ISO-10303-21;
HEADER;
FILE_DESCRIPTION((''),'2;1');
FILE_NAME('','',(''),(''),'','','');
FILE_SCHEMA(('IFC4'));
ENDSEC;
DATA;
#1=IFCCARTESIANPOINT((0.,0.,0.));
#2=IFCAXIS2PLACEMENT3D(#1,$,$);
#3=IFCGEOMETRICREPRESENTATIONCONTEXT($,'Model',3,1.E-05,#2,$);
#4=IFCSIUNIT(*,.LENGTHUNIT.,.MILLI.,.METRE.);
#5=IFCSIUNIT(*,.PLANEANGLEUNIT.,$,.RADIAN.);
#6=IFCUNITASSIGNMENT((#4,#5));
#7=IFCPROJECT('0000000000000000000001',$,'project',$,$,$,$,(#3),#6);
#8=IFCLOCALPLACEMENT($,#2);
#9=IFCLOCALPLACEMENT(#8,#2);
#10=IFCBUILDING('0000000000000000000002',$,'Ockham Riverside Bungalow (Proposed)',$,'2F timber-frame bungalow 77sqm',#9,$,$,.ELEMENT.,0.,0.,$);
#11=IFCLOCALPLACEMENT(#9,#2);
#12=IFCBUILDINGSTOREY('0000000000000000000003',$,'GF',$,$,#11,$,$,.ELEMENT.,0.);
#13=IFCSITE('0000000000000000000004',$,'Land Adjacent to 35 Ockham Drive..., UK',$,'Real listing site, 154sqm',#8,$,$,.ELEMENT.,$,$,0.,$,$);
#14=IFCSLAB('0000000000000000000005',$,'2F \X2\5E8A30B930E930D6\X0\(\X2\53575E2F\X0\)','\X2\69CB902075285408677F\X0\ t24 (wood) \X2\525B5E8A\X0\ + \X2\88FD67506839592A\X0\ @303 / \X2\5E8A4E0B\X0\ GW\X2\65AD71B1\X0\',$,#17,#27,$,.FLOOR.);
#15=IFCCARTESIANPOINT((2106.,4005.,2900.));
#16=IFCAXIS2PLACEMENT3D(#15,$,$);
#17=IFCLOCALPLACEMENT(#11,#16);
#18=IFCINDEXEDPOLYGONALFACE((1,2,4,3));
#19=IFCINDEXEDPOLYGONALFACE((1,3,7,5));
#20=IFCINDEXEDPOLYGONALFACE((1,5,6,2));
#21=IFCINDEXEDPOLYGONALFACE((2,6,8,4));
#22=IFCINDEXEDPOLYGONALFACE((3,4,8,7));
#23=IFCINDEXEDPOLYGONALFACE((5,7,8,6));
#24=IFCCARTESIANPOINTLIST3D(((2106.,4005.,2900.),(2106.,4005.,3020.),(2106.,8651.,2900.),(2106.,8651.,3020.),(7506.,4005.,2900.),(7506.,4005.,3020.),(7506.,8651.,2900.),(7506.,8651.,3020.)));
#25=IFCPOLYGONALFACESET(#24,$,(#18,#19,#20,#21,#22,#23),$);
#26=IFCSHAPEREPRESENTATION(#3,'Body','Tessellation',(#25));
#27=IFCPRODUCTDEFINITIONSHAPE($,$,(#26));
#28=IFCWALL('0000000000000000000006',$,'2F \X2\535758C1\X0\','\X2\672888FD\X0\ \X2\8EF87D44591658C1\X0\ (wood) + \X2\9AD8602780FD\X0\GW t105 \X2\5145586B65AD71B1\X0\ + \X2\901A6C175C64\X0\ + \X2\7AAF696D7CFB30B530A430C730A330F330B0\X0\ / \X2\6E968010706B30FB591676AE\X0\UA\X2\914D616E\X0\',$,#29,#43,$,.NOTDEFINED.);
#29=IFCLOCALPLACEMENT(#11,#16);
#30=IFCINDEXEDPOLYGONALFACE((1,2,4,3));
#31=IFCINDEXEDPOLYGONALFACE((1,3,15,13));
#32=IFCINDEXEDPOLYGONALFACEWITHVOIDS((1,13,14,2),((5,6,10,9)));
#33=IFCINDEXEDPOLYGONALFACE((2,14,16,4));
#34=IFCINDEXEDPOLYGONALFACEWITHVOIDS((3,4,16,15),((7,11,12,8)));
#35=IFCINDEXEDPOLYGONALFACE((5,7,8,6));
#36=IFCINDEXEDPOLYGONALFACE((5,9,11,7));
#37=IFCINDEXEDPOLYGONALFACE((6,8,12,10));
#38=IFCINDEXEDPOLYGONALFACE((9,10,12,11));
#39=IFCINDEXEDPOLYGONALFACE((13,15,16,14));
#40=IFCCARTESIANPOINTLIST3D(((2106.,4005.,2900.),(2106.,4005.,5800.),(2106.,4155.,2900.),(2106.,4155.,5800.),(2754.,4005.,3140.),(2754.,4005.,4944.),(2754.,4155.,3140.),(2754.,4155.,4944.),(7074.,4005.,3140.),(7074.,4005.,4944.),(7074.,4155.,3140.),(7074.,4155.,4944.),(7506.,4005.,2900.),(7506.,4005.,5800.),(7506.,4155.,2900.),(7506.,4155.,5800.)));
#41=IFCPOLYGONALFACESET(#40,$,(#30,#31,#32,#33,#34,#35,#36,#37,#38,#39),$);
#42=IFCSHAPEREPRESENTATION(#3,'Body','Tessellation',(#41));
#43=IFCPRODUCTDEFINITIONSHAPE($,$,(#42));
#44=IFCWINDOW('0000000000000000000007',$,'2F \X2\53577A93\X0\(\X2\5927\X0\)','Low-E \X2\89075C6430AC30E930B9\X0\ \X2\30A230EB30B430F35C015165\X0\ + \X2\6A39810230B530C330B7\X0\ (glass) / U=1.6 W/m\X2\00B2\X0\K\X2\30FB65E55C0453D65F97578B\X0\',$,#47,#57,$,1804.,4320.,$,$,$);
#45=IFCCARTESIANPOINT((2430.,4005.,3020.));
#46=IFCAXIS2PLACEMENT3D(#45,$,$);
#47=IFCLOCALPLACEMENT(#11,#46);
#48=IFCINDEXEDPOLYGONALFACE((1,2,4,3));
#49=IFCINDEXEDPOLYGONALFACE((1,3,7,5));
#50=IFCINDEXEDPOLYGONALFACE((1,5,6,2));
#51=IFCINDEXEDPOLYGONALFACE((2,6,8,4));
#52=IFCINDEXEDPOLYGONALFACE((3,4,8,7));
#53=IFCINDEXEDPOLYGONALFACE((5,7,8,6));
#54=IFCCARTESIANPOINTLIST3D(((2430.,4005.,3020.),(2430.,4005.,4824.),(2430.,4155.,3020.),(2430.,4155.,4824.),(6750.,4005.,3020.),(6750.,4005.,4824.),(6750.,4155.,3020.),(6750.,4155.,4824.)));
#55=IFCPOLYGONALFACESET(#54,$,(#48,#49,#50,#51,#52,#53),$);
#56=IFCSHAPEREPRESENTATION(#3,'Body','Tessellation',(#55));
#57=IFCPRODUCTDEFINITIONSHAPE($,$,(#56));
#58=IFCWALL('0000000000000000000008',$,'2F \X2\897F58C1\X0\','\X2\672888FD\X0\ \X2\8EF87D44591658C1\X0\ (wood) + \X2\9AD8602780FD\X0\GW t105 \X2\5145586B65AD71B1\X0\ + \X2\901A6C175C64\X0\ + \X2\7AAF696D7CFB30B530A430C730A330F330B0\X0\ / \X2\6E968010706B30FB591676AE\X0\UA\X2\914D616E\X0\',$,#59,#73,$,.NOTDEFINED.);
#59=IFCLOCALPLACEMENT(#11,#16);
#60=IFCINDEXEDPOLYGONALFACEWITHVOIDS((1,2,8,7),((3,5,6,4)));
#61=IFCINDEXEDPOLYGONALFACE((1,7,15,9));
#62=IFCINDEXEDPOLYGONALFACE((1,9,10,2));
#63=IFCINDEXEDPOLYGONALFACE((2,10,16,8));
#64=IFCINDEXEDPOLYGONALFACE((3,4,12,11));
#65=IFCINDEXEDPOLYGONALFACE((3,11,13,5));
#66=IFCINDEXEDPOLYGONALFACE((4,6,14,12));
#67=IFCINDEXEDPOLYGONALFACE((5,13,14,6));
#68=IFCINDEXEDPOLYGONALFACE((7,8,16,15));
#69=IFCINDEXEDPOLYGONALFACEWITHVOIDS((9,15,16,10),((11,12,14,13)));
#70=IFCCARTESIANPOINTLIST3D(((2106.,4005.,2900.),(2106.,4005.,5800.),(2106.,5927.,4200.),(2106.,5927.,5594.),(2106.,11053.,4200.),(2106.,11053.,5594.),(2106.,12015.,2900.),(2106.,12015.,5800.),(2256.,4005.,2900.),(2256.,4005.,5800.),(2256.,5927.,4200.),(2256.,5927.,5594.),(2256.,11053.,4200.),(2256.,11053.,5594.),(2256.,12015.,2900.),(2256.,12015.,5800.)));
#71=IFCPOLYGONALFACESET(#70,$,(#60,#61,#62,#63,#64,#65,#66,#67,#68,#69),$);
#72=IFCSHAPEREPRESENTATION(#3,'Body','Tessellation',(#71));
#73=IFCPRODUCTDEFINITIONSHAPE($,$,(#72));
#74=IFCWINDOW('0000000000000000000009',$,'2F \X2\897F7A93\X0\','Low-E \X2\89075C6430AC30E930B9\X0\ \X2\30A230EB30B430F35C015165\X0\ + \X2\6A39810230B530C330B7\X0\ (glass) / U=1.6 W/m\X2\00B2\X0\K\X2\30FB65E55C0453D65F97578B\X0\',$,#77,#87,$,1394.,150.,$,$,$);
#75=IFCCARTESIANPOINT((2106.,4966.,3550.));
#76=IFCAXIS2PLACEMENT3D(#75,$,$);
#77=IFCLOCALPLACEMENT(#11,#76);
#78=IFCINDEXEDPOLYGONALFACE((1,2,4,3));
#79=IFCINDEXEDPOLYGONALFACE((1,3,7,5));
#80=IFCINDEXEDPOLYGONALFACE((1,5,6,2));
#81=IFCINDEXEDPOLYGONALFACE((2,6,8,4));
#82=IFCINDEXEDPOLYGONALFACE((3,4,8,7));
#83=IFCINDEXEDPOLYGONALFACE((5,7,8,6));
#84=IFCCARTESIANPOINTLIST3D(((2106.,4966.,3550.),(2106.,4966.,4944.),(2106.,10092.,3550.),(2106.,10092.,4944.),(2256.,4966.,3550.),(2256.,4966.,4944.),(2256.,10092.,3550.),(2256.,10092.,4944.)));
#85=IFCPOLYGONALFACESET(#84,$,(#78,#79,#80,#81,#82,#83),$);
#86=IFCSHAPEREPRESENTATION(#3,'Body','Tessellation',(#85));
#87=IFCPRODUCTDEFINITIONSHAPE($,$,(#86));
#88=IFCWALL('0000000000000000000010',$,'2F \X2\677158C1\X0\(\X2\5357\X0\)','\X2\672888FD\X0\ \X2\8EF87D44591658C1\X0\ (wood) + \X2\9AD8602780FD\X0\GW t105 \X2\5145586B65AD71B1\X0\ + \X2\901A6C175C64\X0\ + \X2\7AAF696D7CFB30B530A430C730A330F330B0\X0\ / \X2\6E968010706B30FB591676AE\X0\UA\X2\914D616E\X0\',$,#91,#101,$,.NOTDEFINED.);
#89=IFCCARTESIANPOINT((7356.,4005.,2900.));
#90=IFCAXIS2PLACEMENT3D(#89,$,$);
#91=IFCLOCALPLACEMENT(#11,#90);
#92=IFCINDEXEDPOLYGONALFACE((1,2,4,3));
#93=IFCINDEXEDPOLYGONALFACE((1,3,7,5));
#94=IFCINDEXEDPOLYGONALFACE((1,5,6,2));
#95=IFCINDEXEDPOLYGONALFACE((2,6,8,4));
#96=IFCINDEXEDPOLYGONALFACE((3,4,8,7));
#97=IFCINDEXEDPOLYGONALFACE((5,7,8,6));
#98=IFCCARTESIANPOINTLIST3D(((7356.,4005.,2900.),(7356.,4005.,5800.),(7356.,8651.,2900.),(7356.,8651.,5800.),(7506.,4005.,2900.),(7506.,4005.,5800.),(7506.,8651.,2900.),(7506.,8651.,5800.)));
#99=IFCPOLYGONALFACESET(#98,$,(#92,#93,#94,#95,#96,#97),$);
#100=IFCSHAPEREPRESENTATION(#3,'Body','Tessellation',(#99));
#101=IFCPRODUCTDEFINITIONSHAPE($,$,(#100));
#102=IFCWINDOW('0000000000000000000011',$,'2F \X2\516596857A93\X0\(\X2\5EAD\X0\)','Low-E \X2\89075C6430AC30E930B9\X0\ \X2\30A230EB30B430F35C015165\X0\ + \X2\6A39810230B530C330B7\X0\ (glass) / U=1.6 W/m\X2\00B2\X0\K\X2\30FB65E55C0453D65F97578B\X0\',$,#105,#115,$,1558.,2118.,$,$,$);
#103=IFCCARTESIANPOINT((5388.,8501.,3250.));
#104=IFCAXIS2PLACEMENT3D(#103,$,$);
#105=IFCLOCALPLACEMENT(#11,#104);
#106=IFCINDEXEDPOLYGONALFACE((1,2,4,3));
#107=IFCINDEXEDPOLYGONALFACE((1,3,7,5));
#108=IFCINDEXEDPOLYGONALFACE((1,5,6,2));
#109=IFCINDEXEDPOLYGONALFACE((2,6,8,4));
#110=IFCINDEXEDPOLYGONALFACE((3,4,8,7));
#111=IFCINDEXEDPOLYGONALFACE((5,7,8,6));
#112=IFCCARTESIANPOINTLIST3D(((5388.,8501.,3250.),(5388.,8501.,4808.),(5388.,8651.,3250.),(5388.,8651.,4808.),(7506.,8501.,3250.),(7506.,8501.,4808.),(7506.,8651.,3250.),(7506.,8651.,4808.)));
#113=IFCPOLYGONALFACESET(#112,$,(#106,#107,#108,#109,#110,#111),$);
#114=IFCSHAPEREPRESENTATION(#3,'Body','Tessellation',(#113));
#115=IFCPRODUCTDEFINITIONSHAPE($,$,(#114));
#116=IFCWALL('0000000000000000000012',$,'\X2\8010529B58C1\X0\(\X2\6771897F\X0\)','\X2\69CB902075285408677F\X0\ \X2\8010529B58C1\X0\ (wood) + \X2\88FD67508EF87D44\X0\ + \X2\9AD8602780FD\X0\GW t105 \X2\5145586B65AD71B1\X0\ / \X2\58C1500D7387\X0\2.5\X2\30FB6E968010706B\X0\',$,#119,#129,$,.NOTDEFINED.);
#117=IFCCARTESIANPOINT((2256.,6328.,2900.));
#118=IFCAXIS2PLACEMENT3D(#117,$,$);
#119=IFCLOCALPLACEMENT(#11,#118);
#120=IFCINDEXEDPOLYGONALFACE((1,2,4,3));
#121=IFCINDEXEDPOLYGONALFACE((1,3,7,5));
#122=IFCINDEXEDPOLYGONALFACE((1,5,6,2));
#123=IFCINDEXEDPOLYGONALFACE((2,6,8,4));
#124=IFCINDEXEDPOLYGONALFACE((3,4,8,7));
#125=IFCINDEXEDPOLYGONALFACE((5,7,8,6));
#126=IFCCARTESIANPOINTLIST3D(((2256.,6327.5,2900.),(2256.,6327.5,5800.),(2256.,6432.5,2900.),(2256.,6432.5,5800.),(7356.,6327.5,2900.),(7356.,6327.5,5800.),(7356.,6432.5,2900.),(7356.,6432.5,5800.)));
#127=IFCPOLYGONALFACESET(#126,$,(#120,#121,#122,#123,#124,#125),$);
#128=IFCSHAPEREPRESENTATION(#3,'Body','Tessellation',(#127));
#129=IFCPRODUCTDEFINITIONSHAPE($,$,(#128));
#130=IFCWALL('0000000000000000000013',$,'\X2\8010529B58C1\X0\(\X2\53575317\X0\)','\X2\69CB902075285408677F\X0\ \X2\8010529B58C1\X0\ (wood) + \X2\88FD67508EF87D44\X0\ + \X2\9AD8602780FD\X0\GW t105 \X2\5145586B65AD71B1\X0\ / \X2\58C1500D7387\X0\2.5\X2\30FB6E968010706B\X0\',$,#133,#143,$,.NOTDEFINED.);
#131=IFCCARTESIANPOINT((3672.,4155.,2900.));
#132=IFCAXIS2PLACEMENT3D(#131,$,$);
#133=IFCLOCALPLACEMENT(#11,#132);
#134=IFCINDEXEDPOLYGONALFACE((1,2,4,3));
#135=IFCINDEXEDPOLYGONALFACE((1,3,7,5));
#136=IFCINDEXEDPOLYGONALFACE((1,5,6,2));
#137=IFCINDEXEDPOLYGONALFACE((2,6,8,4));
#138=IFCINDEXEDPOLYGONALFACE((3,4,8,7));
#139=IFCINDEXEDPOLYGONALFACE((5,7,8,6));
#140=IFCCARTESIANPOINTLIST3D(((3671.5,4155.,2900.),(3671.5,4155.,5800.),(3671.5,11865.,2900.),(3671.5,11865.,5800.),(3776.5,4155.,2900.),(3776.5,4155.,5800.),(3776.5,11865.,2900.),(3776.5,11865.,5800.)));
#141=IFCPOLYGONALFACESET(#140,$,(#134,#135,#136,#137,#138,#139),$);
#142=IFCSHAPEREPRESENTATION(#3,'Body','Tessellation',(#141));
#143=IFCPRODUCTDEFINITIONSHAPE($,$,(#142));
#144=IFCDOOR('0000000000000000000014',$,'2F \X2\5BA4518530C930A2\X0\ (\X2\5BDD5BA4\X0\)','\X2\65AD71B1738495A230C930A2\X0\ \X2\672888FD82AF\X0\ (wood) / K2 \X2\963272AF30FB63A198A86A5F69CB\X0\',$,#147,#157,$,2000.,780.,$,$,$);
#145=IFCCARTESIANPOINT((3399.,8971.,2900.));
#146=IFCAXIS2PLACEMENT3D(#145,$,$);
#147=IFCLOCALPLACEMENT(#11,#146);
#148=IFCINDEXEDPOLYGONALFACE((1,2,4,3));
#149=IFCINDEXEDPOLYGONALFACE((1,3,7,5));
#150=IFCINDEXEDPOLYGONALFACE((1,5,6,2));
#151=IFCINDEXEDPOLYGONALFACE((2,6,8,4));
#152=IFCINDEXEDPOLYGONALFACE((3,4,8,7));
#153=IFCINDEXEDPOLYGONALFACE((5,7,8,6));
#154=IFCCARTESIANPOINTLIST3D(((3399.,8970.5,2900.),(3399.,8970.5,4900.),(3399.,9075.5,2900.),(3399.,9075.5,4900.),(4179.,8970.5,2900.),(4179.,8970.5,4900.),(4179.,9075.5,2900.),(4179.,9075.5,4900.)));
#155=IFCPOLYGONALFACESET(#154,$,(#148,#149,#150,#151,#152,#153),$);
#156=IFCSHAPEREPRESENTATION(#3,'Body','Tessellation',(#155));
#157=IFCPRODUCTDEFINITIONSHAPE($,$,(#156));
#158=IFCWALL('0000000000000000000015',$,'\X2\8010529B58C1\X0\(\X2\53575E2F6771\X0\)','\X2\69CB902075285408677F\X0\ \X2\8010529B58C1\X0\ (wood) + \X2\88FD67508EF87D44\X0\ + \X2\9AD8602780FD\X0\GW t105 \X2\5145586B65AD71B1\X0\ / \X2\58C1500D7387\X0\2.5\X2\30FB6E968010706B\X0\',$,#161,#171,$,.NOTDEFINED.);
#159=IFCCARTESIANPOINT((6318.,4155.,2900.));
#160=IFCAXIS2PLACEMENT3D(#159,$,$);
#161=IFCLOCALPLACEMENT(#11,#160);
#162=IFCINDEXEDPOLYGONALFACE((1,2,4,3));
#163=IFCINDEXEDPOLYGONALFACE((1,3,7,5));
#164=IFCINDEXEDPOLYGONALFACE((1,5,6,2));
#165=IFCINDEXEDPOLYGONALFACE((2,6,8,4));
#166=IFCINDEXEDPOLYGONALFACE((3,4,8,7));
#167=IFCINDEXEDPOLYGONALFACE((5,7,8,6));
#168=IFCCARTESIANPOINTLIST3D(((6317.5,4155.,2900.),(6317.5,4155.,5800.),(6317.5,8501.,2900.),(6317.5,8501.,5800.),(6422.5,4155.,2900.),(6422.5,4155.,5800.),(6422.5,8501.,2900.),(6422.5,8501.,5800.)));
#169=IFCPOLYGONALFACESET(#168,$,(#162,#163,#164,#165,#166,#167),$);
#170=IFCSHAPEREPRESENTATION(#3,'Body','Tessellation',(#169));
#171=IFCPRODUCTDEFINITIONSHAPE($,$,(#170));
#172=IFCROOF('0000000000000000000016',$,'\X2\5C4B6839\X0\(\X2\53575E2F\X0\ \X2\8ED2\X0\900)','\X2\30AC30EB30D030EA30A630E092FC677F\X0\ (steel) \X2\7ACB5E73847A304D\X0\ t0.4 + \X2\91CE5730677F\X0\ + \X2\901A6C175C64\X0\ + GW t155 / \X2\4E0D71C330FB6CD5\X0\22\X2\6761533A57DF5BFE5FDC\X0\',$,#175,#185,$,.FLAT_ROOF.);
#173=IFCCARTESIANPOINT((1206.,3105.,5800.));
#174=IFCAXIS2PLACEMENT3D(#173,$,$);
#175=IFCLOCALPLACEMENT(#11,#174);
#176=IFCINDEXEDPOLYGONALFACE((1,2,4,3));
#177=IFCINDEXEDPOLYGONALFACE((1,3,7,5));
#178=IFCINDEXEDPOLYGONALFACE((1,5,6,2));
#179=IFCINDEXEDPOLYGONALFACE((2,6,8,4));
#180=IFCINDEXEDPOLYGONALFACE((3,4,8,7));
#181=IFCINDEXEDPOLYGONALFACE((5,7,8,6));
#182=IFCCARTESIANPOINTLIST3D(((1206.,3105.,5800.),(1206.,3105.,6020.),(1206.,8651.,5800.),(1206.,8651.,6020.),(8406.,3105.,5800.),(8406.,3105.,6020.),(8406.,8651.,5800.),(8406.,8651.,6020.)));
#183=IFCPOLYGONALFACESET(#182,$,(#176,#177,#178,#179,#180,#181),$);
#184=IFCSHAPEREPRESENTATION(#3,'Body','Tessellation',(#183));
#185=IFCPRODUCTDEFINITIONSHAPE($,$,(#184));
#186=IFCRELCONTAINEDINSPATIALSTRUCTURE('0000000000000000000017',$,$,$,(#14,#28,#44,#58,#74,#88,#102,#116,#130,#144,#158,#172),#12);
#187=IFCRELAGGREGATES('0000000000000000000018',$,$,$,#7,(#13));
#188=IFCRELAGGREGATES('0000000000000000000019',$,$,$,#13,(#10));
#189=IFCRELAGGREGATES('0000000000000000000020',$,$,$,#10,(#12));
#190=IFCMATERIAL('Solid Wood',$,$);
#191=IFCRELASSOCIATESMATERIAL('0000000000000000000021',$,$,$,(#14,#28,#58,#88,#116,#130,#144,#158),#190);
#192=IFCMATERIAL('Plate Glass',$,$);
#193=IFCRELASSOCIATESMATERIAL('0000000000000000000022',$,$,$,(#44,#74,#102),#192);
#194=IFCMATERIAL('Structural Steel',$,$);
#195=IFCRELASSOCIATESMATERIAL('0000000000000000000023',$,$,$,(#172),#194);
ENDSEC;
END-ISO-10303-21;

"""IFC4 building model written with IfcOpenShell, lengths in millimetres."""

from ifc_helpers import new_model, si_unit, frame, frame_2d, origin, place, context, project, spatial, rectangle, extrude, material, element, fill, save


model = new_model("IFC4")

# Units and contexts
model_context = context("Model", 3, precision=1e-05, world=origin())
ifc_project = project(units=[si_unit("LENGTHUNIT", "METRE", prefix="MILLI"), si_unit("PLANEANGLEUNIT", "RADIAN")], contexts=[model_context])

# Site, building, storey
site_placement = place(None, origin())
site = spatial("IfcSite", under=ifc_project, at=site_placement, Name="Land Adjacent to 35 Ockham Drive..., UK", ObjectType="Real listing site, 154sqm", CompositionType="ELEMENT", RefElevation=0.0)
building_placement = place(site_placement, origin())
building = spatial("IfcBuilding", under=site, at=building_placement, Name="Ockham Riverside Bungalow (Proposed)", ObjectType="2F timber-frame bungalow 77sqm", CompositionType="ELEMENT", ElevationOfRefHeight=0.0, ElevationOfTerrain=0.0)
storey_placement = place(building_placement, origin())
storey = spatial("IfcBuildingStorey", under=building, at=storey_placement, Name="GF", CompositionType="ELEMENT", Elevation=0.0)

# Slab
ifc_material_1 = material(Name="Solid Wood")
slab_placement = place(storey_placement, frame((2106.0, 4005.0, 2900.0)))
element("IfcSlab", 1, at=slab_placement, inside=storey, material=ifc_material_1, Name="2F 床スラブ(南帯)", Description="構造用合板 t24 (wood) 剛床 + 製材根太 @303 / 床下 GW断熱", PredefinedType="FLOOR", context=model_context, shape_type="SweptSolid", body=[
    extrude(rectangle(XDim=5400.0, YDim=4646.0, at=frame_2d((2700.0, 2323.0))), frame((2106.0, 4005.0, 2900.0)), (0.0, 0.0, 1.0), 120.0),
])

# Walls, openings, windows
wall_1_placement = place(storey_placement, frame((2106.0, 4005.0, 2900.0)))
wall_1 = element("IfcWall", 2, at=wall_1_placement, inside=storey, material=ifc_material_1, Name="2F 南壁", Description="木製 軸組外壁 (wood) + 高性能GW t105 充填断熱 + 通気層 + 窯業系サイディング / 準耐火・外皮UA配慮", PredefinedType="NOTDEFINED", context=model_context, shape_type="SweptSolid", body=[
    extrude(rectangle(XDim=5400.0, YDim=150.0, at=frame_2d((2700.0, 75.0))), frame((2106.0, 4005.0, 2900.0)), (0.0, 0.0, 1.0), 2900.0),
])
opening_1_placement = place(storey_placement, frame((2430.0, 4005.0, 3020.0)))
opening_1 = element("IfcOpeningElement", 3, at=opening_1_placement, cuts=wall_1, PredefinedType="NOTDEFINED", context=model_context, shape_type="SweptSolid", body=[
    extrude(rectangle(XDim=4320.0, YDim=150.0, at=frame_2d((2160.0, 75.0))), frame((2430.0, 4005.0, 3020.0)), (0.0, 0.0, 1.0), 1804.0),
])
ifc_material_2 = material(Name="Plate Glass")
window_1_placement = place(storey_placement, frame((2430.0, 4005.0, 3020.0)))
window_1 = element("IfcWindow", 4, at=window_1_placement, inside=storey, material=ifc_material_2, Name="2F 南窓(大)", Description="Low-E 複層ガラス アルゴン封入 + 樹脂サッシ (glass) / U=1.6 W/m²K・日射取得型", OverallHeight=1804.0, OverallWidth=4320.0, context=model_context, shape_type="SweptSolid", body=[
    extrude(rectangle(XDim=4320.0, YDim=150.0, at=frame_2d((2160.0, 75.0))), frame((2430.0, 4005.0, 3020.0)), (0.0, 0.0, 1.0), 1804.0),
])
fill(opening_1, window_1)
wall_2_placement = place(storey_placement, frame((2106.0, 4005.0, 2900.0)))
wall_2 = element("IfcWall", 5, at=wall_2_placement, inside=storey, material=ifc_material_1, Name="2F 西壁", Description="木製 軸組外壁 (wood) + 高性能GW t105 充填断熱 + 通気層 + 窯業系サイディング / 準耐火・外皮UA配慮", PredefinedType="NOTDEFINED", context=model_context, shape_type="SweptSolid", body=[
    extrude(rectangle(XDim=150.0, YDim=8010.0, at=frame_2d((75.0, 4005.0))), frame((2106.0, 4005.0, 2900.0)), (0.0, 0.0, 1.0), 2900.0),
])
opening_2_placement = place(storey_placement, frame((2106.0, 4966.0, 3550.0)))
opening_2 = element("IfcOpeningElement", 6, at=opening_2_placement, cuts=wall_2, PredefinedType="NOTDEFINED", context=model_context, shape_type="SweptSolid", body=[
    extrude(rectangle(XDim=150.0, YDim=5126.0, at=frame_2d((75.0, 2563.0))), frame((2106.0, 4966.0, 3550.0)), (0.0, 0.0, 1.0), 1394.0),
])
window_2_placement = place(storey_placement, frame((2106.0, 4966.0, 3550.0)))
window_2 = element("IfcWindow", 7, at=window_2_placement, inside=storey, material=ifc_material_2, Name="2F 西窓", Description="Low-E 複層ガラス アルゴン封入 + 樹脂サッシ (glass) / U=1.6 W/m²K・日射取得型", OverallHeight=1394.0, OverallWidth=150.0, context=model_context, shape_type="SweptSolid", body=[
    extrude(rectangle(XDim=150.0, YDim=5126.0, at=frame_2d((75.0, 2563.0))), frame((2106.0, 4966.0, 3550.0)), (0.0, 0.0, 1.0), 1394.0),
])
fill(opening_2, window_2)
wall_3_placement = place(storey_placement, frame((7356.0, 4005.0, 2900.0)))
wall_3 = element("IfcWall", 8, at=wall_3_placement, inside=storey, material=ifc_material_1, Name="2F 東壁(南)", Description="木製 軸組外壁 (wood) + 高性能GW t105 充填断熱 + 通気層 + 窯業系サイディング / 準耐火・外皮UA配慮", PredefinedType="NOTDEFINED", context=model_context, shape_type="SweptSolid", body=[
    extrude(rectangle(XDim=150.0, YDim=4646.0, at=frame_2d((75.0, 2323.0))), frame((7356.0, 4005.0, 2900.0)), (0.0, 0.0, 1.0), 2900.0),
])
opening_3_placement = place(storey_placement, frame((5388.0, 8501.0, 3250.0)))
opening_3 = element("IfcOpeningElement", 9, at=opening_3_placement, cuts=wall_3, PredefinedType="NOTDEFINED", context=model_context, shape_type="SweptSolid", body=[
    extrude(rectangle(XDim=2118.0, YDim=150.0, at=frame_2d((1059.0, 75.0))), frame((5388.0, 8501.0, 3250.0)), (0.0, 0.0, 1.0), 1558.0),
])
window_3_placement = place(storey_placement, frame((5388.0, 8501.0, 3250.0)))
window_3 = element("IfcWindow", 10, at=window_3_placement, inside=storey, material=ifc_material_2, Name="2F 入隅窓(庭)", Description="Low-E 複層ガラス アルゴン封入 + 樹脂サッシ (glass) / U=1.6 W/m²K・日射取得型", OverallHeight=1558.0, OverallWidth=2118.0, context=model_context, shape_type="SweptSolid", body=[
    extrude(rectangle(XDim=2118.0, YDim=150.0, at=frame_2d((1059.0, 75.0))), frame((5388.0, 8501.0, 3250.0)), (0.0, 0.0, 1.0), 1558.0),
])
fill(opening_3, window_3)

# Wall
wall_4_placement = place(storey_placement, frame((2256.0, 6328.0, 2900.0)))
element("IfcWall", 11, at=wall_4_placement, inside=storey, material=ifc_material_1, Name="耐力壁(東西)", Description="構造用合板 耐力壁 (wood) + 製材軸組 + 高性能GW t105 充填断熱 / 壁倍率2.5・準耐火", PredefinedType="NOTDEFINED", context=model_context, shape_type="SweptSolid", body=[
    extrude(rectangle(XDim=5100.0, YDim=105.0, at=frame_2d((2550.0, 52.0))), frame((2256.0, 6328.0, 2900.0)), (0.0, 0.0, 1.0), 2900.0),
])

# Wall, opening, door
wall_5_placement = place(storey_placement, frame((3672.0, 4155.0, 2900.0)))
wall_5 = element("IfcWall", 12, at=wall_5_placement, inside=storey, material=ifc_material_1, Name="耐力壁(南北)", Description="構造用合板 耐力壁 (wood) + 製材軸組 + 高性能GW t105 充填断熱 / 壁倍率2.5・準耐火", PredefinedType="NOTDEFINED", context=model_context, shape_type="SweptSolid", body=[
    extrude(rectangle(XDim=105.0, YDim=7710.0, at=frame_2d((52.0, 3855.0))), frame((3672.0, 4155.0, 2900.0)), (0.0, 0.0, 1.0), 2900.0),
])
opening_4_placement = place(storey_placement, frame((3399.0, 8971.0, 2900.0)))
opening_4 = element("IfcOpeningElement", 13, at=opening_4_placement, cuts=wall_5, PredefinedType="NOTDEFINED", context=model_context, shape_type="SweptSolid", body=[
    extrude(rectangle(XDim=780.0, YDim=105.0, at=frame_2d((390.0, 52.0))), frame((3399.0, 8971.0, 2900.0)), (0.0, 0.0, 1.0), 2000.0),
])
door_placement = place(storey_placement, frame((3399.0, 8971.0, 2900.0)))
door = element("IfcDoor", 14, at=door_placement, inside=storey, material=ifc_material_1, Name="2F 室内ドア (寝室)", Description="断熱玄関ドア 木製芯 (wood) / K2 防犯・採風機構", OverallHeight=2000.0, OverallWidth=780.0, context=model_context, shape_type="SweptSolid", body=[
    extrude(rectangle(XDim=780.0, YDim=105.0, at=frame_2d((390.0, 52.0))), frame((3399.0, 8971.0, 2900.0)), (0.0, 0.0, 1.0), 2000.0),
])
fill(opening_4, door)

# Wall
wall_6_placement = place(storey_placement, frame((6318.0, 4155.0, 2900.0)))
element("IfcWall", 15, at=wall_6_placement, inside=storey, material=ifc_material_1, Name="耐力壁(南帯東)", Description="構造用合板 耐力壁 (wood) + 製材軸組 + 高性能GW t105 充填断熱 / 壁倍率2.5・準耐火", PredefinedType="NOTDEFINED", context=model_context, shape_type="SweptSolid", body=[
    extrude(rectangle(XDim=105.0, YDim=4346.0, at=frame_2d((52.0, 2173.0))), frame((6318.0, 4155.0, 2900.0)), (0.0, 0.0, 1.0), 2900.0),
])

# Roof
ifc_material_3 = material(Name="Structural Steel")
for number, where, name in (
    (16, (1206.0, 3105.0, 5800.0), "屋根(南帯 軒900)"),
):
    element("IfcRoof", number, at=place(storey_placement, frame(where)), inside=storey, material=ifc_material_3, Name=name, Description="ガルバリウム鋼板 (steel) 立平葺き t0.4 + 野地板 + 通気層 + GW t155 / 不燃・法22条区域対応", PredefinedType="FLAT_ROOF", context=model_context, shape_type="SweptSolid", body=[
        extrude(rectangle(XDim=7200.0, YDim=5546.0, at=frame_2d((3600.0, 2773.0))), frame((1206.0, 3105.0, 5800.0)), (0.0, 0.0, 1.0), 220.0),
    ])

save(model, "model.ifc")
